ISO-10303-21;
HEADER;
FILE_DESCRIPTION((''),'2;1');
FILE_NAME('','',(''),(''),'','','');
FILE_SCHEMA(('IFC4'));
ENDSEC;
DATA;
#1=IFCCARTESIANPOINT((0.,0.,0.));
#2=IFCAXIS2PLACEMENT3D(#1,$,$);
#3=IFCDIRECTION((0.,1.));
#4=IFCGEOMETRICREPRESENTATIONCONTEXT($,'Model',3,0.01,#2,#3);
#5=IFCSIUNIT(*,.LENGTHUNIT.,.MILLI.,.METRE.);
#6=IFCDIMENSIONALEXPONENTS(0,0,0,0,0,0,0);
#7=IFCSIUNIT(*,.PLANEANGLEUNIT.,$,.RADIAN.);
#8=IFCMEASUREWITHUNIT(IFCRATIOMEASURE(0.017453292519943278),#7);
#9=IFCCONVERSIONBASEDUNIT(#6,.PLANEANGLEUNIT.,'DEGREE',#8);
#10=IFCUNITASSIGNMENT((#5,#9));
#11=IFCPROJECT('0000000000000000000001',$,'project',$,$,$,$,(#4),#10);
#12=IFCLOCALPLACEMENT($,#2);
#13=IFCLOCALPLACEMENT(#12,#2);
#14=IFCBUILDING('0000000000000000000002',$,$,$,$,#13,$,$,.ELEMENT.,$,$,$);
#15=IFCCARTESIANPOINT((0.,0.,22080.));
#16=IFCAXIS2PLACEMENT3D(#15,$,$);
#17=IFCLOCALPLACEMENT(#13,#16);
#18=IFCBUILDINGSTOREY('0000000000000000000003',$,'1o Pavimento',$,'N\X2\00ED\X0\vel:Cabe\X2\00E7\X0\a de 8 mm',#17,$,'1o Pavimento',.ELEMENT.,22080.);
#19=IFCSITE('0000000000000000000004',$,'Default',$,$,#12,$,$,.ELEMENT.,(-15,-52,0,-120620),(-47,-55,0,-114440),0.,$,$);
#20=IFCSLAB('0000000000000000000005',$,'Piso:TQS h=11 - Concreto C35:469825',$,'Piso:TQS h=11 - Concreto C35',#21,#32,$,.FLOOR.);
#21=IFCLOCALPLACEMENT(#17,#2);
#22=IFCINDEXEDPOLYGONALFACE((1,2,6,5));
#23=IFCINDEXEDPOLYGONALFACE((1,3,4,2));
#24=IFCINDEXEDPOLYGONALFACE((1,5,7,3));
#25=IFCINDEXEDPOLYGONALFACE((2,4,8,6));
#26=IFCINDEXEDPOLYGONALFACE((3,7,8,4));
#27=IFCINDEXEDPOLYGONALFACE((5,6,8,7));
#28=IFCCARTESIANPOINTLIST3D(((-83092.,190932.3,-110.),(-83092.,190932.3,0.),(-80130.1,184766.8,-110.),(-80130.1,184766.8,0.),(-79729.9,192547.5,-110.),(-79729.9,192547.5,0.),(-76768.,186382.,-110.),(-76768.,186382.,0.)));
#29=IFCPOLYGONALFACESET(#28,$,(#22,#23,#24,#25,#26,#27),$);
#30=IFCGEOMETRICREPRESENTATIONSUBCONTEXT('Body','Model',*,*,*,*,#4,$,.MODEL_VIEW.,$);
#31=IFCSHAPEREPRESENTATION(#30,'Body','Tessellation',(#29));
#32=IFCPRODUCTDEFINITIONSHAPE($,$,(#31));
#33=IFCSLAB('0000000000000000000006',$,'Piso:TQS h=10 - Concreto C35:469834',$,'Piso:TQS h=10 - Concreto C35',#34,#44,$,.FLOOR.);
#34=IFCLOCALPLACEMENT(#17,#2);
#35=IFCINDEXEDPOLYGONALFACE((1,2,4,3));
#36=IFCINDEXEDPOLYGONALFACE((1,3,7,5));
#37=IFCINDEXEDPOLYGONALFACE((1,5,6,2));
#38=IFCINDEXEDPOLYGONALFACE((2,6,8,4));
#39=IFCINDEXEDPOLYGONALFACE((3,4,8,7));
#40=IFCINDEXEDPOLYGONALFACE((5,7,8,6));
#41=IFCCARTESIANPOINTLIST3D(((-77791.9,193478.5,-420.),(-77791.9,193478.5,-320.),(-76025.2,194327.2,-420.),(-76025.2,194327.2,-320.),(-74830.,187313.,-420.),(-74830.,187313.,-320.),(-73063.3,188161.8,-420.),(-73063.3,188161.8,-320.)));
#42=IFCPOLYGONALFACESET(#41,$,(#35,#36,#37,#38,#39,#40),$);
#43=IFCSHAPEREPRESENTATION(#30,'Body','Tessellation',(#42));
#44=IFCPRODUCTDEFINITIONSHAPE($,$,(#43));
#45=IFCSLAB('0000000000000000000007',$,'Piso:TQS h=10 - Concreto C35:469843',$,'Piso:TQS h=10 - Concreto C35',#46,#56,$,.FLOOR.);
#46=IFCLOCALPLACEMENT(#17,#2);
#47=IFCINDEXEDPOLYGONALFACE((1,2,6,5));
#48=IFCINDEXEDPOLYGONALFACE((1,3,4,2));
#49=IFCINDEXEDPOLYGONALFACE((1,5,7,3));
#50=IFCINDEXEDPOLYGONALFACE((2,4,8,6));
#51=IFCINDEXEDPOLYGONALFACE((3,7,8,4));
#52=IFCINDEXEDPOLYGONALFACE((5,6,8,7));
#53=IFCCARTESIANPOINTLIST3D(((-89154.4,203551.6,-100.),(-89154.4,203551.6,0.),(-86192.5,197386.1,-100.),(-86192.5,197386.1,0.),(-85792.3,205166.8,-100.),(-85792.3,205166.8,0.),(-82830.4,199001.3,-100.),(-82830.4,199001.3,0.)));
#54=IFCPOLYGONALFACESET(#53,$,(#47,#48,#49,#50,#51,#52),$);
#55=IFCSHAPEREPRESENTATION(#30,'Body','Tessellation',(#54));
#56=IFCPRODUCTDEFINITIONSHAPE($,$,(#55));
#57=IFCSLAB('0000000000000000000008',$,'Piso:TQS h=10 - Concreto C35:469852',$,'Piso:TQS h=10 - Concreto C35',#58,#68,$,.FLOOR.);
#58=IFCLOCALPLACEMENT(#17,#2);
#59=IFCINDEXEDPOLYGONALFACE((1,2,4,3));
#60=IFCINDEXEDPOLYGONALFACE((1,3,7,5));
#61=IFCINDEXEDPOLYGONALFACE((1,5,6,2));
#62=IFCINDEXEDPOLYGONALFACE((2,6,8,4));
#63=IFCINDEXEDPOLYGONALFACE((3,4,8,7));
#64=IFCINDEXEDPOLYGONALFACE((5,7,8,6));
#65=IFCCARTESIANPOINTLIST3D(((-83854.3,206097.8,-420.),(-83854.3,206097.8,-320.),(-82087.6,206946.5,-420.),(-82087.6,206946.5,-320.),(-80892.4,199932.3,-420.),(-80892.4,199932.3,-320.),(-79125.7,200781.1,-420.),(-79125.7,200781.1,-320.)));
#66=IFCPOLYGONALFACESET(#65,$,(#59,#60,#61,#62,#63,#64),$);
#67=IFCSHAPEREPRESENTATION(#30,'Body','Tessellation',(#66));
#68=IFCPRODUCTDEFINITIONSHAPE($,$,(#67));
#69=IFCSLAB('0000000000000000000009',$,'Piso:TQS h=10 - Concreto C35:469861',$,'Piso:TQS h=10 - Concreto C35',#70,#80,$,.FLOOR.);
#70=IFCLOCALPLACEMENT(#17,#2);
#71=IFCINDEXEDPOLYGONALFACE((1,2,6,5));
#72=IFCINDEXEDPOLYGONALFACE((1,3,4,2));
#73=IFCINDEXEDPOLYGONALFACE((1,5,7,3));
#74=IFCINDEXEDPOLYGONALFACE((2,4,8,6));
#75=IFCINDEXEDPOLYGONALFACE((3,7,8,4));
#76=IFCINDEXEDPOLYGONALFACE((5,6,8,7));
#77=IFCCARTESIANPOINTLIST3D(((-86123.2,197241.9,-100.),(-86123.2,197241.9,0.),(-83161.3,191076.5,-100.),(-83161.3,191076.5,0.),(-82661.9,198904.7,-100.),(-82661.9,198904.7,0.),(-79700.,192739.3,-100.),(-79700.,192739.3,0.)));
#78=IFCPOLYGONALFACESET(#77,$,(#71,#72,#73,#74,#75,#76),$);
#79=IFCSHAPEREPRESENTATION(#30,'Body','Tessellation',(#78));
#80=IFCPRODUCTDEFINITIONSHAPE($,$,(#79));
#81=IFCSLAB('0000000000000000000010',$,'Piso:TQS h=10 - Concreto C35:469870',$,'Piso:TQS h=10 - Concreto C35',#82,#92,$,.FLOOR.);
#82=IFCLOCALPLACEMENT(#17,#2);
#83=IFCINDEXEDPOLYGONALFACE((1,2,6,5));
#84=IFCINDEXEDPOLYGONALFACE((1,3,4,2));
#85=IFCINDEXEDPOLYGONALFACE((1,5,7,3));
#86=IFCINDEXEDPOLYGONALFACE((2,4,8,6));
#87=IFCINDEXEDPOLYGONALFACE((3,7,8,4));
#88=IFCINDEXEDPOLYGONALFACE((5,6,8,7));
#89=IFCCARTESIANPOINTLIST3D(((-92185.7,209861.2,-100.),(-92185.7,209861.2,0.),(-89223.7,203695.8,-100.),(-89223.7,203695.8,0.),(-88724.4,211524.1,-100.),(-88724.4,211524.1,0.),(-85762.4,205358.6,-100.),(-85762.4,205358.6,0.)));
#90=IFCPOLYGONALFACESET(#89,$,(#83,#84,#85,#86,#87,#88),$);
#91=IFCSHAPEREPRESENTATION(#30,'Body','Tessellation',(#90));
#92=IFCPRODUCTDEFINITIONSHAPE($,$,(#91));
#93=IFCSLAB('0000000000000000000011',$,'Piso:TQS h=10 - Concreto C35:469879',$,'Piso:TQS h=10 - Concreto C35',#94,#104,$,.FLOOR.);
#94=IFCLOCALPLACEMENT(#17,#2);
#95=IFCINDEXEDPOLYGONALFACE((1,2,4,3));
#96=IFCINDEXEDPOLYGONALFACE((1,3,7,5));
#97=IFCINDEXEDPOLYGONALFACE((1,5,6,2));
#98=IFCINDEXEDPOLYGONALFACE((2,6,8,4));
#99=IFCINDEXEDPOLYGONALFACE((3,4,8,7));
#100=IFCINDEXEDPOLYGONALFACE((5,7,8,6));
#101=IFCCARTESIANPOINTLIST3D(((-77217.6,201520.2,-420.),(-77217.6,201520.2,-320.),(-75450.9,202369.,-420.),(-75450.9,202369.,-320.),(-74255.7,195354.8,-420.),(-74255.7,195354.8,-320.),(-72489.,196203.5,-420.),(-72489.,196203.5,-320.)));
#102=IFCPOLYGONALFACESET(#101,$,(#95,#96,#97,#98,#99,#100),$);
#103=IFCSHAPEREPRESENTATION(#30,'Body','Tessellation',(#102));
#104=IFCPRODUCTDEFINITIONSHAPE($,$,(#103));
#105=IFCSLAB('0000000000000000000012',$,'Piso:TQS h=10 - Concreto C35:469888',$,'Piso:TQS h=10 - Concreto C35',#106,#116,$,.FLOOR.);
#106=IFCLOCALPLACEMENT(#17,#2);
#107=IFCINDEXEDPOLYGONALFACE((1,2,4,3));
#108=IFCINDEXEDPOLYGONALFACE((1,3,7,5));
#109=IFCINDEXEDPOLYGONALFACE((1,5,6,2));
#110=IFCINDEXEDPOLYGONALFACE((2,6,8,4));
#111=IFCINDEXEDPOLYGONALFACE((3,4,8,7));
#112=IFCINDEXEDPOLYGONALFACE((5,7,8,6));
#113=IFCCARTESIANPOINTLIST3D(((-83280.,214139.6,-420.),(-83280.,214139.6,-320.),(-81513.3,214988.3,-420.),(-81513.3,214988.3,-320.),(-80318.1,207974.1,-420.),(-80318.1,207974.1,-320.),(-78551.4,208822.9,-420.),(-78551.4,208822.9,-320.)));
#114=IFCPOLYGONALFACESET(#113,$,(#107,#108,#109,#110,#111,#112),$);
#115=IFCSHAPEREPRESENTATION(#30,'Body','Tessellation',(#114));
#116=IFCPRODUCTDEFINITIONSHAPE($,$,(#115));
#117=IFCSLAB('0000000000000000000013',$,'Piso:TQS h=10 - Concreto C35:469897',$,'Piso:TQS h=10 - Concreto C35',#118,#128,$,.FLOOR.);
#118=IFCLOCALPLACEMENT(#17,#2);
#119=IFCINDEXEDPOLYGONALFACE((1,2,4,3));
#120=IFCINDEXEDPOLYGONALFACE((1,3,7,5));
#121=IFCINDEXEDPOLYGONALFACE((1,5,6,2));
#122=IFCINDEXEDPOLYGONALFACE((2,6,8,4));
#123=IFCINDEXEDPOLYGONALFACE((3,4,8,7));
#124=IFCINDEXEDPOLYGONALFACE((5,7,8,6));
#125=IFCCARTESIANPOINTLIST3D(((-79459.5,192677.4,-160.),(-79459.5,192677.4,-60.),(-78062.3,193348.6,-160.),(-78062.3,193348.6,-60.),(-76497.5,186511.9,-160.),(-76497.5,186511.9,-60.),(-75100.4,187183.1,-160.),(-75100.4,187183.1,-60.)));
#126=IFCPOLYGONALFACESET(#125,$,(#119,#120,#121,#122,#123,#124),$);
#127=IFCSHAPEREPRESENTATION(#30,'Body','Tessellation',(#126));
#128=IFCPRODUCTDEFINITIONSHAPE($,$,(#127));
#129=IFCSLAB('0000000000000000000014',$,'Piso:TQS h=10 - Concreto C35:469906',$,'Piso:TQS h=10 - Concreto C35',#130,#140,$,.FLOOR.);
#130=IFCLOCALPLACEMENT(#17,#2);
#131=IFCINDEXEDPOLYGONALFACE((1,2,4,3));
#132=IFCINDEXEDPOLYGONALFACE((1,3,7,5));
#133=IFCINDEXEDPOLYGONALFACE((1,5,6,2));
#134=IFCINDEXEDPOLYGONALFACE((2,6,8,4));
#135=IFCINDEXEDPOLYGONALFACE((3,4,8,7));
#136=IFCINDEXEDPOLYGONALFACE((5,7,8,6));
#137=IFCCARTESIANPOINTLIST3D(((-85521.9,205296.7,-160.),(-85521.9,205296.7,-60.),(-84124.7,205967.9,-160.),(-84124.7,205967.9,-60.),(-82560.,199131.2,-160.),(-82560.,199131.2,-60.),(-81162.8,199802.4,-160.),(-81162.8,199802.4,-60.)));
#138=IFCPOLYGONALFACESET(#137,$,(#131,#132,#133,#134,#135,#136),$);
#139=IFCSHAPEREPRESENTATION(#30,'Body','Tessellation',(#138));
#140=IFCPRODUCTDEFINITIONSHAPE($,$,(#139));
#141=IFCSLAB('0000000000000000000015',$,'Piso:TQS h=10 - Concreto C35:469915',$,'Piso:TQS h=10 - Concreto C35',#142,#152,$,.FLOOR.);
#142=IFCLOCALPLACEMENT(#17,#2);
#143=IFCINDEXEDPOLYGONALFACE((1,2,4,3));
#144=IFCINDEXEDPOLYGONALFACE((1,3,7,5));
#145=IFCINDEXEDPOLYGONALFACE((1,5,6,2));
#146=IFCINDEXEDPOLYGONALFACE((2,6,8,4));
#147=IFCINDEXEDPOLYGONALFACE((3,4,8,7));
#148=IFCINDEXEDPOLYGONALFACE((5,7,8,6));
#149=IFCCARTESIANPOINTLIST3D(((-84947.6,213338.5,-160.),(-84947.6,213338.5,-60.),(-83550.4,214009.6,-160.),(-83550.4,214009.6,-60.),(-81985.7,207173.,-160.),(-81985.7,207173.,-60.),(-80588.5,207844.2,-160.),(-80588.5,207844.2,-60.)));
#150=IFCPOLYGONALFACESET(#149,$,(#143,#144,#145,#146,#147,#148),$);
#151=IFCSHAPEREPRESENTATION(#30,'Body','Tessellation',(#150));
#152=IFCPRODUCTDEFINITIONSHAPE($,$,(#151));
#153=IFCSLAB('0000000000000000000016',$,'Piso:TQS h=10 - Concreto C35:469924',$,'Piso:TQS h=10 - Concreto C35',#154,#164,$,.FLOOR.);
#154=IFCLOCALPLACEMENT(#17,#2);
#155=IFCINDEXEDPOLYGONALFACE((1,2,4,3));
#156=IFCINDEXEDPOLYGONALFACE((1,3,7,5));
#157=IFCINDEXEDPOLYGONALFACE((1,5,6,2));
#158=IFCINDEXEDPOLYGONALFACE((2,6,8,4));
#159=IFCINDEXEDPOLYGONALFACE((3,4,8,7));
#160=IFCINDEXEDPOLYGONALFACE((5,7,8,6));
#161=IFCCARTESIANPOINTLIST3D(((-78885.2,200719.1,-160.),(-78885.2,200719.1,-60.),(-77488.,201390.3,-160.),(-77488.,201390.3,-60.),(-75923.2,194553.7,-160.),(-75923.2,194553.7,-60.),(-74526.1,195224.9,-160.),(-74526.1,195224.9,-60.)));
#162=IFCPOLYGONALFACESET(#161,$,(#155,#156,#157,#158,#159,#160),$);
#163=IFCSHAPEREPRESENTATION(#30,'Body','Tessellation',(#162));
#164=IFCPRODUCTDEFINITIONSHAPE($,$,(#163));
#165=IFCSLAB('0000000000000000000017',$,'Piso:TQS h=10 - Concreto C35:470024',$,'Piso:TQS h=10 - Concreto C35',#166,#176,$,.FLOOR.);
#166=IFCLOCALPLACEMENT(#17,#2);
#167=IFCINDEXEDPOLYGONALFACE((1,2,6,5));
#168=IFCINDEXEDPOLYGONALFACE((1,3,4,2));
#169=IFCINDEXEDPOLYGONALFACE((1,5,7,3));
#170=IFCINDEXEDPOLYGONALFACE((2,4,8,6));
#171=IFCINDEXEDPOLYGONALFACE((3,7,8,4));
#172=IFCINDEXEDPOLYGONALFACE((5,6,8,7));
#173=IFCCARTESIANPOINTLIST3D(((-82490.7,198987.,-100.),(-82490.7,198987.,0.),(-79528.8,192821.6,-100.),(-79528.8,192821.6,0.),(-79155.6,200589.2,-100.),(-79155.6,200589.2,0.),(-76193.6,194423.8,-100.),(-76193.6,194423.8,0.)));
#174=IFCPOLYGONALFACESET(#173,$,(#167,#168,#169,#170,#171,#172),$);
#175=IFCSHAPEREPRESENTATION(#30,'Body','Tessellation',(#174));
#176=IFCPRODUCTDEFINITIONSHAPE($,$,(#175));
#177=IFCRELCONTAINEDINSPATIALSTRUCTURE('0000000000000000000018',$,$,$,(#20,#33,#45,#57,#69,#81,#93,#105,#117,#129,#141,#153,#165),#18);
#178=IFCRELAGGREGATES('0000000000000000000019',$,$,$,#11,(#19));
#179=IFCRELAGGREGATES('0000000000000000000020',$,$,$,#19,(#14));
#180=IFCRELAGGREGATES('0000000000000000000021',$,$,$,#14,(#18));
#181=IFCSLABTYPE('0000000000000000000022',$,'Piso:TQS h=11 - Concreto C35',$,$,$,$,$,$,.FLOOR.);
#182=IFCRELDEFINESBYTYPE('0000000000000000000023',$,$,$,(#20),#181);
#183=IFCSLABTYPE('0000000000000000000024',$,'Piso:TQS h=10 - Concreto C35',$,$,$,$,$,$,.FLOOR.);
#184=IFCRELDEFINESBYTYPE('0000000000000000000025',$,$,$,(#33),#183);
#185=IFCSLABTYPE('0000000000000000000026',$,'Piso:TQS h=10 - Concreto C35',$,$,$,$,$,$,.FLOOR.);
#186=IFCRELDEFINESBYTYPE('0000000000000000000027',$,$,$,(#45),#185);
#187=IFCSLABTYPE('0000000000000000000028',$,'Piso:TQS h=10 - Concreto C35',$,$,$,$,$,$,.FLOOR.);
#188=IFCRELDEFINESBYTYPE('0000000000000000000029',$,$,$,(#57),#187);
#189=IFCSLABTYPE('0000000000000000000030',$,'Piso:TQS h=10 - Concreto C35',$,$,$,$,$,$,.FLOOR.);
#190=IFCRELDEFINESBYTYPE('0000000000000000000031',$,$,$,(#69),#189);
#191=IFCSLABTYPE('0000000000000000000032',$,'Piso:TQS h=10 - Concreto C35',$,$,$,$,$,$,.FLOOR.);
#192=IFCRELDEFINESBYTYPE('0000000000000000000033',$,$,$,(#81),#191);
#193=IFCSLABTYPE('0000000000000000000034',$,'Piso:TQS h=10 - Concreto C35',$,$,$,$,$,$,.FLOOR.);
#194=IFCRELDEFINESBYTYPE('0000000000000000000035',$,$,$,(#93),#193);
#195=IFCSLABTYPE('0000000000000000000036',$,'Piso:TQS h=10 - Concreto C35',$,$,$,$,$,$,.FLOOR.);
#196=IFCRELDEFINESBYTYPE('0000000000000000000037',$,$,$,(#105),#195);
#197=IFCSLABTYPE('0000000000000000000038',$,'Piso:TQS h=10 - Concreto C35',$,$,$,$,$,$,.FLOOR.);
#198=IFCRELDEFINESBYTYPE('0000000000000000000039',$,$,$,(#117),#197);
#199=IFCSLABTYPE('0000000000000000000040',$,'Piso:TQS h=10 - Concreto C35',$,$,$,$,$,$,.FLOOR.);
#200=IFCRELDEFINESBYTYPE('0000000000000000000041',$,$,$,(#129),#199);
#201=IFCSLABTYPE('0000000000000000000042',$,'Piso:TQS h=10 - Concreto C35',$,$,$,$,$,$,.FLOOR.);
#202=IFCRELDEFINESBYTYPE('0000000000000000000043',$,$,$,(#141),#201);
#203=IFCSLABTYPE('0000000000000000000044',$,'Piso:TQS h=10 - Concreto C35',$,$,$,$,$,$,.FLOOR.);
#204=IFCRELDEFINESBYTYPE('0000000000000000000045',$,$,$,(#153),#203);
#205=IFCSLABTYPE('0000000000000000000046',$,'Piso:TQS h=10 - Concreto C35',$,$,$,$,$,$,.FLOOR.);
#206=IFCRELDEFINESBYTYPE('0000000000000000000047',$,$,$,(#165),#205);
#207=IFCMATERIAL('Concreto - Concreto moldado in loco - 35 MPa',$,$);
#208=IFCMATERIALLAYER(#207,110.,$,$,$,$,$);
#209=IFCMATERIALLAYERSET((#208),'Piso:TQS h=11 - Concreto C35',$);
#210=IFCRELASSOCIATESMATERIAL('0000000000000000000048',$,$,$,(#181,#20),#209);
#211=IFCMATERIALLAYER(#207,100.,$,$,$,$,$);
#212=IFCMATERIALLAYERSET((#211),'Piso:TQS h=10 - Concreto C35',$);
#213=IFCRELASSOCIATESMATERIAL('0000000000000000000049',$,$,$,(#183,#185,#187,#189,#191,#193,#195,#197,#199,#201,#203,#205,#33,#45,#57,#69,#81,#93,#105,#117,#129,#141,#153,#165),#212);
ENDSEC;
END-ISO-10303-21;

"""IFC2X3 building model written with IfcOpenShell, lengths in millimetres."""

from ifc_helpers import new_model, entity, si_unit, converted_unit, direction, frame, frame_2d, origin, place, context, subcontext, project, spatial, rectangle, extrude, material, layer, layer_set, layer_usage, type_object, element, save


model = new_model("IFC2X3")

# Units and contexts
model_context = context("Model", 3, precision=0.01, world=origin(), true_north=direction((0.0, 1.0)))
body_context = subcontext(model_context, "Body", "Model", "MODEL_VIEW")
ifc_project = project(units=[si_unit("LENGTHUNIT", "METRE", prefix="MILLI"), converted_unit("PLANEANGLEUNIT", "DEGREE", entity("IfcRatioMeasure", 0.017453292519943278), si_unit("PLANEANGLEUNIT", "RADIAN"), dimensions=[0, 0, 0, 0, 0, 0, 0])], contexts=[model_context])

# Site, building, storey
site_placement = place(None, origin())
site = spatial("IfcSite", under=ifc_project, at=site_placement, Name="Default", CompositionType="ELEMENT", RefLatitude=(-15, -52, 0, -120620), RefLongitude=(-47, -55, 0, -114440), RefElevation=0.0)
building_placement = place(site_placement, origin())
building = spatial("IfcBuilding", under=site, at=building_placement, CompositionType="ELEMENT")
storey_placement = place(building_placement, frame((0.0, 0.0, 22080.0)))
storey = spatial("IfcBuildingStorey", under=building, at=storey_placement, Name="1o Pavimento", ObjectType="Nível:Cabeça de 8 mm", LongName="1o Pavimento", CompositionType="ELEMENT", Elevation=22080.0)

# Shared definitions
ifc_material_1 = material(Name="Concreto - Concreto moldado in loco - 35 MPa")

# Slabs
ifc_layer_1 = layer(ifc_material_1, 110.0)
ifc_layer_set_1 = layer_set([ifc_layer_1], Name="Piso:TQS h=11 - Concreto C35")
ifc_layer_usage_1 = layer_usage(ifc_layer_set_1, "AXIS3", "POSITIVE", 0.0)
slab_type_1 = type_object("IfcSlabType", Name="Piso:TQS h=11 - Concreto C35", PredefinedType="FLOOR", material=ifc_layer_set_1)
slab_1_placement = place(storey_placement, origin())
element("IfcSlab", 1, at=slab_1_placement, inside=storey, type_object=slab_type_1, material=ifc_layer_usage_1, Name="Piso:TQS h=11 - Concreto C35:469825", ObjectType="Piso:TQS h=11 - Concreto C35", PredefinedType="FLOOR", context=body_context, shape_type="SweptSolid", body=[
    extrude(rectangle(XDim=6840.0, YDim=3730.0, at=frame_2d((0.0, 0.0), x_axis=(1.0, 0.0))), frame((-79930.0, 188657.1, 0.0), z_axis=(0.0, 0.0, -1.0), x_axis=(0.43303, -0.90138, 0.0)), (0.0, 0.0, 1.0), 110.0),
])
ifc_layer_2 = layer(ifc_material_1, 100.0)
ifc_layer_set_2 = layer_set([ifc_layer_2], Name="Piso:TQS h=10 - Concreto C35")
ifc_layer_usage_2 = layer_usage(ifc_layer_set_2, "AXIS3", "POSITIVE", 0.0)
slab_type_2 = type_object("IfcSlabType", Name="Piso:TQS h=10 - Concreto C35", PredefinedType="FLOOR", material=ifc_layer_set_2)
slab_2_placement = place(storey_placement, origin())
element("IfcSlab", 2, at=slab_2_placement, inside=storey, type_object=slab_type_2, material=ifc_layer_usage_2, Name="Piso:TQS h=10 - Concreto C35:469834", ObjectType="Piso:TQS h=10 - Concreto C35", PredefinedType="FLOOR", context=body_context, shape_type="SweptSolid", body=[
    extrude(rectangle(XDim=6840.0, YDim=1960.0, at=frame_2d((0.0, 0.0), x_axis=(1.0, 0.0))), frame((-75427.6, 190820.1, -320.0), z_axis=(0.0, 0.0, -1.0), x_axis=(0.43303, -0.90138, 0.0)), (0.0, 0.0, 1.0), 100.0),
])
ifc_layer_usage_3 = layer_usage(ifc_layer_set_2, "AXIS3", "POSITIVE", 0.0)
slab_type_3 = type_object("IfcSlabType", Name="Piso:TQS h=10 - Concreto C35", PredefinedType="FLOOR", material=ifc_layer_set_2)
slab_3_placement = place(storey_placement, origin())
element("IfcSlab", 3, at=slab_3_placement, inside=storey, type_object=slab_type_3, material=ifc_layer_usage_3, Name="Piso:TQS h=10 - Concreto C35:469843", ObjectType="Piso:TQS h=10 - Concreto C35", PredefinedType="FLOOR", context=body_context, shape_type="SweptSolid", body=[
    extrude(rectangle(XDim=6840.0, YDim=3730.0, at=frame_2d((0.0, 0.0), x_axis=(1.0, 0.0))), frame((-85992.4, 201276.4, 0.0), z_axis=(0.0, 0.0, -1.0), x_axis=(0.43303, -0.90138, 0.0)), (0.0, 0.0, 1.0), 100.0),
])
ifc_layer_usage_4 = layer_usage(ifc_layer_set_2, "AXIS3", "POSITIVE", 0.0)
slab_type_4 = type_object("IfcSlabType", Name="Piso:TQS h=10 - Concreto C35", PredefinedType="FLOOR", material=ifc_layer_set_2)
slab_4_placement = place(storey_placement, origin())
element("IfcSlab", 4, at=slab_4_placement, inside=storey, type_object=slab_type_4, material=ifc_layer_usage_4, Name="Piso:TQS h=10 - Concreto C35:469852", ObjectType="Piso:TQS h=10 - Concreto C35", PredefinedType="FLOOR", context=body_context, shape_type="SweptSolid", body=[
    extrude(rectangle(XDim=6840.0, YDim=1960.0, at=frame_2d((0.0, 0.0), x_axis=(1.0, 0.0))), frame((-81490.0, 203439.4, -320.0), z_axis=(0.0, 0.0, -1.0), x_axis=(0.43303, -0.90138, 0.0)), (0.0, 0.0, 1.0), 100.0),
])
ifc_layer_usage_5 = layer_usage(ifc_layer_set_2, "AXIS3", "POSITIVE", 0.0)
slab_type_5 = type_object("IfcSlabType", Name="Piso:TQS h=10 - Concreto C35", PredefinedType="FLOOR", material=ifc_layer_set_2)
slab_5_placement = place(storey_placement, origin())
element("IfcSlab", 5, at=slab_5_placement, inside=storey, type_object=slab_type_5, material=ifc_layer_usage_5, Name="Piso:TQS h=10 - Concreto C35:469861", ObjectType="Piso:TQS h=10 - Concreto C35", PredefinedType="FLOOR", context=body_context, shape_type="SweptSolid", body=[
    extrude(rectangle(XDim=6840.0, YDim=3840.0, at=frame_2d((0.0, 0.0), x_axis=(1.0, 0.0))), frame((-82911.6, 194990.6, 0.0), z_axis=(0.0, 0.0, -1.0), x_axis=(0.43303, -0.90138, 0.0)), (0.0, 0.0, 1.0), 100.0),
])
ifc_layer_usage_6 = layer_usage(ifc_layer_set_2, "AXIS3", "POSITIVE", 0.0)
slab_type_6 = type_object("IfcSlabType", Name="Piso:TQS h=10 - Concreto C35", PredefinedType="FLOOR", material=ifc_layer_set_2)
slab_6_placement = place(storey_placement, origin())
element("IfcSlab", 6, at=slab_6_placement, inside=storey, type_object=slab_type_6, material=ifc_layer_usage_6, Name="Piso:TQS h=10 - Concreto C35:469870", ObjectType="Piso:TQS h=10 - Concreto C35", PredefinedType="FLOOR", context=body_context, shape_type="SweptSolid", body=[
    extrude(rectangle(XDim=6840.0, YDim=3840.0, at=frame_2d((0.0, 0.0), x_axis=(1.0, 0.0))), frame((-88974.0, 207609.9, 0.0), z_axis=(0.0, 0.0, -1.0), x_axis=(0.43303, -0.90138, 0.0)), (0.0, 0.0, 1.0), 100.0),
])
ifc_layer_usage_7 = layer_usage(ifc_layer_set_2, "AXIS3", "POSITIVE", 0.0)
slab_type_7 = type_object("IfcSlabType", Name="Piso:TQS h=10 - Concreto C35", PredefinedType="FLOOR", material=ifc_layer_set_2)
slab_7_placement = place(storey_placement, origin())
element("IfcSlab", 7, at=slab_7_placement, inside=storey, type_object=slab_type_7, material=ifc_layer_usage_7, Name="Piso:TQS h=10 - Concreto C35:469879", ObjectType="Piso:TQS h=10 - Concreto C35", PredefinedType="FLOOR", context=body_context, shape_type="SweptSolid", body=[
    extrude(rectangle(XDim=6840.0, YDim=1960.0, at=frame_2d((0.0, 0.0), x_axis=(1.0, 0.0))), frame((-74853.3, 198861.9, -320.0), z_axis=(0.0, 0.0, -1.0), x_axis=(0.43303, -0.90138, 0.0)), (0.0, 0.0, 1.0), 100.0),
])
ifc_layer_usage_8 = layer_usage(ifc_layer_set_2, "AXIS3", "POSITIVE", 0.0)
slab_type_8 = type_object("IfcSlabType", Name="Piso:TQS h=10 - Concreto C35", PredefinedType="FLOOR", material=ifc_layer_set_2)
slab_8_placement = place(storey_placement, origin())
element("IfcSlab", 8, at=slab_8_placement, inside=storey, type_object=slab_type_8, material=ifc_layer_usage_8, Name="Piso:TQS h=10 - Concreto C35:469888", ObjectType="Piso:TQS h=10 - Concreto C35", PredefinedType="FLOOR", context=body_context, shape_type="SweptSolid", body=[
    extrude(rectangle(XDim=6840.0, YDim=1960.0, at=frame_2d((0.0, 0.0), x_axis=(1.0, 0.0))), frame((-80915.7, 211481.2, -320.0), z_axis=(0.0, 0.0, -1.0), x_axis=(0.43303, -0.90138, 0.0)), (0.0, 0.0, 1.0), 100.0),
])
ifc_layer_usage_9 = layer_usage(ifc_layer_set_2, "AXIS3", "POSITIVE", 0.0)
slab_type_9 = type_object("IfcSlabType", Name="Piso:TQS h=10 - Concreto C35", PredefinedType="FLOOR", material=ifc_layer_set_2)
slab_9_placement = place(storey_placement, origin())
element("IfcSlab", 9, at=slab_9_placement, inside=storey, type_object=slab_type_9, material=ifc_layer_usage_9, Name="Piso:TQS h=10 - Concreto C35:469897", ObjectType="Piso:TQS h=10 - Concreto C35", PredefinedType="FLOOR", context=body_context, shape_type="SweptSolid", body=[
    extrude(rectangle(XDim=6840.0, YDim=1550.0, at=frame_2d((0.0, 0.0), x_axis=(1.0, 0.0))), frame((-77279.9, 189930.2, -60.0), z_axis=(0.0, 0.0, -1.0), x_axis=(0.43303, -0.90138, 0.0)), (0.0, 0.0, 1.0), 100.0),
])
ifc_layer_usage_10 = layer_usage(ifc_layer_set_2, "AXIS3", "POSITIVE", 0.0)
slab_type_10 = type_object("IfcSlabType", Name="Piso:TQS h=10 - Concreto C35", PredefinedType="FLOOR", material=ifc_layer_set_2)
slab_10_placement = place(storey_placement, origin())
element("IfcSlab", 10, at=slab_10_placement, inside=storey, type_object=slab_type_10, material=ifc_layer_usage_10, Name="Piso:TQS h=10 - Concreto C35:469906", ObjectType="Piso:TQS h=10 - Concreto C35", PredefinedType="FLOOR", context=body_context, shape_type="SweptSolid", body=[
    extrude(rectangle(XDim=6840.0, YDim=1550.0, at=frame_2d((0.0, 0.0), x_axis=(1.0, 0.0))), frame((-83342.4, 202549.6, -60.0), z_axis=(0.0, 0.0, -1.0), x_axis=(0.43303, -0.90138, 0.0)), (0.0, 0.0, 1.0), 100.0),
])
ifc_layer_usage_11 = layer_usage(ifc_layer_set_2, "AXIS3", "POSITIVE", 0.0)
slab_type_11 = type_object("IfcSlabType", Name="Piso:TQS h=10 - Concreto C35", PredefinedType="FLOOR", material=ifc_layer_set_2)
slab_11_placement = place(storey_placement, origin())
element("IfcSlab", 11, at=slab_11_placement, inside=storey, type_object=slab_type_11, material=ifc_layer_usage_11, Name="Piso:TQS h=10 - Concreto C35:469915", ObjectType="Piso:TQS h=10 - Concreto C35", PredefinedType="FLOOR", context=body_context, shape_type="SweptSolid", body=[
    extrude(rectangle(XDim=6840.0, YDim=1550.0, at=frame_2d((0.0, 0.0), x_axis=(1.0, 0.0))), frame((-82768.0, 210591.3, -60.0), z_axis=(0.0, 0.0, -1.0), x_axis=(0.43303, -0.90138, 0.0)), (0.0, 0.0, 1.0), 100.0),
])
ifc_layer_usage_12 = layer_usage(ifc_layer_set_2, "AXIS3", "POSITIVE", 0.0)
slab_type_12 = type_object("IfcSlabType", Name="Piso:TQS h=10 - Concreto C35", PredefinedType="FLOOR", material=ifc_layer_set_2)
slab_12_placement = place(storey_placement, origin())
element("IfcSlab", 12, at=slab_12_placement, inside=storey, type_object=slab_type_12, material=ifc_layer_usage_12, Name="Piso:TQS h=10 - Concreto C35:469924", ObjectType="Piso:TQS h=10 - Concreto C35", PredefinedType="FLOOR", context=body_context, shape_type="SweptSolid", body=[
    extrude(rectangle(XDim=6840.0, YDim=1550.0, at=frame_2d((0.0, 0.0), x_axis=(1.0, 0.0))), frame((-76705.6, 197972.0, -60.0), z_axis=(0.0, 0.0, -1.0), x_axis=(0.43303, -0.90138, 0.0)), (0.0, 0.0, 1.0), 100.0),
])
ifc_layer_usage_13 = layer_usage(ifc_layer_set_2, "AXIS3", "POSITIVE", 0.0)
slab_type_13 = type_object("IfcSlabType", Name="Piso:TQS h=10 - Concreto C35", PredefinedType="FLOOR", material=ifc_layer_set_2)
slab_13_placement = place(storey_placement, origin())
element("IfcSlab", 13, at=slab_13_placement, inside=storey, type_object=slab_type_13, material=ifc_layer_usage_13, Name="Piso:TQS h=10 - Concreto C35:470024", ObjectType="Piso:TQS h=10 - Concreto C35", PredefinedType="FLOOR", context=body_context, shape_type="SweptSolid", body=[
    extrude(rectangle(XDim=6840.0, YDim=3700.0, at=frame_2d((0.0, 0.0), x_axis=(1.0, 0.0))), frame((-79342.2, 196705.4, 0.0), z_axis=(0.0, 0.0, -1.0), x_axis=(0.43303, -0.90138, 0.0)), (0.0, 0.0, 1.0), 100.0),
])

save(model, "model.ifc")
